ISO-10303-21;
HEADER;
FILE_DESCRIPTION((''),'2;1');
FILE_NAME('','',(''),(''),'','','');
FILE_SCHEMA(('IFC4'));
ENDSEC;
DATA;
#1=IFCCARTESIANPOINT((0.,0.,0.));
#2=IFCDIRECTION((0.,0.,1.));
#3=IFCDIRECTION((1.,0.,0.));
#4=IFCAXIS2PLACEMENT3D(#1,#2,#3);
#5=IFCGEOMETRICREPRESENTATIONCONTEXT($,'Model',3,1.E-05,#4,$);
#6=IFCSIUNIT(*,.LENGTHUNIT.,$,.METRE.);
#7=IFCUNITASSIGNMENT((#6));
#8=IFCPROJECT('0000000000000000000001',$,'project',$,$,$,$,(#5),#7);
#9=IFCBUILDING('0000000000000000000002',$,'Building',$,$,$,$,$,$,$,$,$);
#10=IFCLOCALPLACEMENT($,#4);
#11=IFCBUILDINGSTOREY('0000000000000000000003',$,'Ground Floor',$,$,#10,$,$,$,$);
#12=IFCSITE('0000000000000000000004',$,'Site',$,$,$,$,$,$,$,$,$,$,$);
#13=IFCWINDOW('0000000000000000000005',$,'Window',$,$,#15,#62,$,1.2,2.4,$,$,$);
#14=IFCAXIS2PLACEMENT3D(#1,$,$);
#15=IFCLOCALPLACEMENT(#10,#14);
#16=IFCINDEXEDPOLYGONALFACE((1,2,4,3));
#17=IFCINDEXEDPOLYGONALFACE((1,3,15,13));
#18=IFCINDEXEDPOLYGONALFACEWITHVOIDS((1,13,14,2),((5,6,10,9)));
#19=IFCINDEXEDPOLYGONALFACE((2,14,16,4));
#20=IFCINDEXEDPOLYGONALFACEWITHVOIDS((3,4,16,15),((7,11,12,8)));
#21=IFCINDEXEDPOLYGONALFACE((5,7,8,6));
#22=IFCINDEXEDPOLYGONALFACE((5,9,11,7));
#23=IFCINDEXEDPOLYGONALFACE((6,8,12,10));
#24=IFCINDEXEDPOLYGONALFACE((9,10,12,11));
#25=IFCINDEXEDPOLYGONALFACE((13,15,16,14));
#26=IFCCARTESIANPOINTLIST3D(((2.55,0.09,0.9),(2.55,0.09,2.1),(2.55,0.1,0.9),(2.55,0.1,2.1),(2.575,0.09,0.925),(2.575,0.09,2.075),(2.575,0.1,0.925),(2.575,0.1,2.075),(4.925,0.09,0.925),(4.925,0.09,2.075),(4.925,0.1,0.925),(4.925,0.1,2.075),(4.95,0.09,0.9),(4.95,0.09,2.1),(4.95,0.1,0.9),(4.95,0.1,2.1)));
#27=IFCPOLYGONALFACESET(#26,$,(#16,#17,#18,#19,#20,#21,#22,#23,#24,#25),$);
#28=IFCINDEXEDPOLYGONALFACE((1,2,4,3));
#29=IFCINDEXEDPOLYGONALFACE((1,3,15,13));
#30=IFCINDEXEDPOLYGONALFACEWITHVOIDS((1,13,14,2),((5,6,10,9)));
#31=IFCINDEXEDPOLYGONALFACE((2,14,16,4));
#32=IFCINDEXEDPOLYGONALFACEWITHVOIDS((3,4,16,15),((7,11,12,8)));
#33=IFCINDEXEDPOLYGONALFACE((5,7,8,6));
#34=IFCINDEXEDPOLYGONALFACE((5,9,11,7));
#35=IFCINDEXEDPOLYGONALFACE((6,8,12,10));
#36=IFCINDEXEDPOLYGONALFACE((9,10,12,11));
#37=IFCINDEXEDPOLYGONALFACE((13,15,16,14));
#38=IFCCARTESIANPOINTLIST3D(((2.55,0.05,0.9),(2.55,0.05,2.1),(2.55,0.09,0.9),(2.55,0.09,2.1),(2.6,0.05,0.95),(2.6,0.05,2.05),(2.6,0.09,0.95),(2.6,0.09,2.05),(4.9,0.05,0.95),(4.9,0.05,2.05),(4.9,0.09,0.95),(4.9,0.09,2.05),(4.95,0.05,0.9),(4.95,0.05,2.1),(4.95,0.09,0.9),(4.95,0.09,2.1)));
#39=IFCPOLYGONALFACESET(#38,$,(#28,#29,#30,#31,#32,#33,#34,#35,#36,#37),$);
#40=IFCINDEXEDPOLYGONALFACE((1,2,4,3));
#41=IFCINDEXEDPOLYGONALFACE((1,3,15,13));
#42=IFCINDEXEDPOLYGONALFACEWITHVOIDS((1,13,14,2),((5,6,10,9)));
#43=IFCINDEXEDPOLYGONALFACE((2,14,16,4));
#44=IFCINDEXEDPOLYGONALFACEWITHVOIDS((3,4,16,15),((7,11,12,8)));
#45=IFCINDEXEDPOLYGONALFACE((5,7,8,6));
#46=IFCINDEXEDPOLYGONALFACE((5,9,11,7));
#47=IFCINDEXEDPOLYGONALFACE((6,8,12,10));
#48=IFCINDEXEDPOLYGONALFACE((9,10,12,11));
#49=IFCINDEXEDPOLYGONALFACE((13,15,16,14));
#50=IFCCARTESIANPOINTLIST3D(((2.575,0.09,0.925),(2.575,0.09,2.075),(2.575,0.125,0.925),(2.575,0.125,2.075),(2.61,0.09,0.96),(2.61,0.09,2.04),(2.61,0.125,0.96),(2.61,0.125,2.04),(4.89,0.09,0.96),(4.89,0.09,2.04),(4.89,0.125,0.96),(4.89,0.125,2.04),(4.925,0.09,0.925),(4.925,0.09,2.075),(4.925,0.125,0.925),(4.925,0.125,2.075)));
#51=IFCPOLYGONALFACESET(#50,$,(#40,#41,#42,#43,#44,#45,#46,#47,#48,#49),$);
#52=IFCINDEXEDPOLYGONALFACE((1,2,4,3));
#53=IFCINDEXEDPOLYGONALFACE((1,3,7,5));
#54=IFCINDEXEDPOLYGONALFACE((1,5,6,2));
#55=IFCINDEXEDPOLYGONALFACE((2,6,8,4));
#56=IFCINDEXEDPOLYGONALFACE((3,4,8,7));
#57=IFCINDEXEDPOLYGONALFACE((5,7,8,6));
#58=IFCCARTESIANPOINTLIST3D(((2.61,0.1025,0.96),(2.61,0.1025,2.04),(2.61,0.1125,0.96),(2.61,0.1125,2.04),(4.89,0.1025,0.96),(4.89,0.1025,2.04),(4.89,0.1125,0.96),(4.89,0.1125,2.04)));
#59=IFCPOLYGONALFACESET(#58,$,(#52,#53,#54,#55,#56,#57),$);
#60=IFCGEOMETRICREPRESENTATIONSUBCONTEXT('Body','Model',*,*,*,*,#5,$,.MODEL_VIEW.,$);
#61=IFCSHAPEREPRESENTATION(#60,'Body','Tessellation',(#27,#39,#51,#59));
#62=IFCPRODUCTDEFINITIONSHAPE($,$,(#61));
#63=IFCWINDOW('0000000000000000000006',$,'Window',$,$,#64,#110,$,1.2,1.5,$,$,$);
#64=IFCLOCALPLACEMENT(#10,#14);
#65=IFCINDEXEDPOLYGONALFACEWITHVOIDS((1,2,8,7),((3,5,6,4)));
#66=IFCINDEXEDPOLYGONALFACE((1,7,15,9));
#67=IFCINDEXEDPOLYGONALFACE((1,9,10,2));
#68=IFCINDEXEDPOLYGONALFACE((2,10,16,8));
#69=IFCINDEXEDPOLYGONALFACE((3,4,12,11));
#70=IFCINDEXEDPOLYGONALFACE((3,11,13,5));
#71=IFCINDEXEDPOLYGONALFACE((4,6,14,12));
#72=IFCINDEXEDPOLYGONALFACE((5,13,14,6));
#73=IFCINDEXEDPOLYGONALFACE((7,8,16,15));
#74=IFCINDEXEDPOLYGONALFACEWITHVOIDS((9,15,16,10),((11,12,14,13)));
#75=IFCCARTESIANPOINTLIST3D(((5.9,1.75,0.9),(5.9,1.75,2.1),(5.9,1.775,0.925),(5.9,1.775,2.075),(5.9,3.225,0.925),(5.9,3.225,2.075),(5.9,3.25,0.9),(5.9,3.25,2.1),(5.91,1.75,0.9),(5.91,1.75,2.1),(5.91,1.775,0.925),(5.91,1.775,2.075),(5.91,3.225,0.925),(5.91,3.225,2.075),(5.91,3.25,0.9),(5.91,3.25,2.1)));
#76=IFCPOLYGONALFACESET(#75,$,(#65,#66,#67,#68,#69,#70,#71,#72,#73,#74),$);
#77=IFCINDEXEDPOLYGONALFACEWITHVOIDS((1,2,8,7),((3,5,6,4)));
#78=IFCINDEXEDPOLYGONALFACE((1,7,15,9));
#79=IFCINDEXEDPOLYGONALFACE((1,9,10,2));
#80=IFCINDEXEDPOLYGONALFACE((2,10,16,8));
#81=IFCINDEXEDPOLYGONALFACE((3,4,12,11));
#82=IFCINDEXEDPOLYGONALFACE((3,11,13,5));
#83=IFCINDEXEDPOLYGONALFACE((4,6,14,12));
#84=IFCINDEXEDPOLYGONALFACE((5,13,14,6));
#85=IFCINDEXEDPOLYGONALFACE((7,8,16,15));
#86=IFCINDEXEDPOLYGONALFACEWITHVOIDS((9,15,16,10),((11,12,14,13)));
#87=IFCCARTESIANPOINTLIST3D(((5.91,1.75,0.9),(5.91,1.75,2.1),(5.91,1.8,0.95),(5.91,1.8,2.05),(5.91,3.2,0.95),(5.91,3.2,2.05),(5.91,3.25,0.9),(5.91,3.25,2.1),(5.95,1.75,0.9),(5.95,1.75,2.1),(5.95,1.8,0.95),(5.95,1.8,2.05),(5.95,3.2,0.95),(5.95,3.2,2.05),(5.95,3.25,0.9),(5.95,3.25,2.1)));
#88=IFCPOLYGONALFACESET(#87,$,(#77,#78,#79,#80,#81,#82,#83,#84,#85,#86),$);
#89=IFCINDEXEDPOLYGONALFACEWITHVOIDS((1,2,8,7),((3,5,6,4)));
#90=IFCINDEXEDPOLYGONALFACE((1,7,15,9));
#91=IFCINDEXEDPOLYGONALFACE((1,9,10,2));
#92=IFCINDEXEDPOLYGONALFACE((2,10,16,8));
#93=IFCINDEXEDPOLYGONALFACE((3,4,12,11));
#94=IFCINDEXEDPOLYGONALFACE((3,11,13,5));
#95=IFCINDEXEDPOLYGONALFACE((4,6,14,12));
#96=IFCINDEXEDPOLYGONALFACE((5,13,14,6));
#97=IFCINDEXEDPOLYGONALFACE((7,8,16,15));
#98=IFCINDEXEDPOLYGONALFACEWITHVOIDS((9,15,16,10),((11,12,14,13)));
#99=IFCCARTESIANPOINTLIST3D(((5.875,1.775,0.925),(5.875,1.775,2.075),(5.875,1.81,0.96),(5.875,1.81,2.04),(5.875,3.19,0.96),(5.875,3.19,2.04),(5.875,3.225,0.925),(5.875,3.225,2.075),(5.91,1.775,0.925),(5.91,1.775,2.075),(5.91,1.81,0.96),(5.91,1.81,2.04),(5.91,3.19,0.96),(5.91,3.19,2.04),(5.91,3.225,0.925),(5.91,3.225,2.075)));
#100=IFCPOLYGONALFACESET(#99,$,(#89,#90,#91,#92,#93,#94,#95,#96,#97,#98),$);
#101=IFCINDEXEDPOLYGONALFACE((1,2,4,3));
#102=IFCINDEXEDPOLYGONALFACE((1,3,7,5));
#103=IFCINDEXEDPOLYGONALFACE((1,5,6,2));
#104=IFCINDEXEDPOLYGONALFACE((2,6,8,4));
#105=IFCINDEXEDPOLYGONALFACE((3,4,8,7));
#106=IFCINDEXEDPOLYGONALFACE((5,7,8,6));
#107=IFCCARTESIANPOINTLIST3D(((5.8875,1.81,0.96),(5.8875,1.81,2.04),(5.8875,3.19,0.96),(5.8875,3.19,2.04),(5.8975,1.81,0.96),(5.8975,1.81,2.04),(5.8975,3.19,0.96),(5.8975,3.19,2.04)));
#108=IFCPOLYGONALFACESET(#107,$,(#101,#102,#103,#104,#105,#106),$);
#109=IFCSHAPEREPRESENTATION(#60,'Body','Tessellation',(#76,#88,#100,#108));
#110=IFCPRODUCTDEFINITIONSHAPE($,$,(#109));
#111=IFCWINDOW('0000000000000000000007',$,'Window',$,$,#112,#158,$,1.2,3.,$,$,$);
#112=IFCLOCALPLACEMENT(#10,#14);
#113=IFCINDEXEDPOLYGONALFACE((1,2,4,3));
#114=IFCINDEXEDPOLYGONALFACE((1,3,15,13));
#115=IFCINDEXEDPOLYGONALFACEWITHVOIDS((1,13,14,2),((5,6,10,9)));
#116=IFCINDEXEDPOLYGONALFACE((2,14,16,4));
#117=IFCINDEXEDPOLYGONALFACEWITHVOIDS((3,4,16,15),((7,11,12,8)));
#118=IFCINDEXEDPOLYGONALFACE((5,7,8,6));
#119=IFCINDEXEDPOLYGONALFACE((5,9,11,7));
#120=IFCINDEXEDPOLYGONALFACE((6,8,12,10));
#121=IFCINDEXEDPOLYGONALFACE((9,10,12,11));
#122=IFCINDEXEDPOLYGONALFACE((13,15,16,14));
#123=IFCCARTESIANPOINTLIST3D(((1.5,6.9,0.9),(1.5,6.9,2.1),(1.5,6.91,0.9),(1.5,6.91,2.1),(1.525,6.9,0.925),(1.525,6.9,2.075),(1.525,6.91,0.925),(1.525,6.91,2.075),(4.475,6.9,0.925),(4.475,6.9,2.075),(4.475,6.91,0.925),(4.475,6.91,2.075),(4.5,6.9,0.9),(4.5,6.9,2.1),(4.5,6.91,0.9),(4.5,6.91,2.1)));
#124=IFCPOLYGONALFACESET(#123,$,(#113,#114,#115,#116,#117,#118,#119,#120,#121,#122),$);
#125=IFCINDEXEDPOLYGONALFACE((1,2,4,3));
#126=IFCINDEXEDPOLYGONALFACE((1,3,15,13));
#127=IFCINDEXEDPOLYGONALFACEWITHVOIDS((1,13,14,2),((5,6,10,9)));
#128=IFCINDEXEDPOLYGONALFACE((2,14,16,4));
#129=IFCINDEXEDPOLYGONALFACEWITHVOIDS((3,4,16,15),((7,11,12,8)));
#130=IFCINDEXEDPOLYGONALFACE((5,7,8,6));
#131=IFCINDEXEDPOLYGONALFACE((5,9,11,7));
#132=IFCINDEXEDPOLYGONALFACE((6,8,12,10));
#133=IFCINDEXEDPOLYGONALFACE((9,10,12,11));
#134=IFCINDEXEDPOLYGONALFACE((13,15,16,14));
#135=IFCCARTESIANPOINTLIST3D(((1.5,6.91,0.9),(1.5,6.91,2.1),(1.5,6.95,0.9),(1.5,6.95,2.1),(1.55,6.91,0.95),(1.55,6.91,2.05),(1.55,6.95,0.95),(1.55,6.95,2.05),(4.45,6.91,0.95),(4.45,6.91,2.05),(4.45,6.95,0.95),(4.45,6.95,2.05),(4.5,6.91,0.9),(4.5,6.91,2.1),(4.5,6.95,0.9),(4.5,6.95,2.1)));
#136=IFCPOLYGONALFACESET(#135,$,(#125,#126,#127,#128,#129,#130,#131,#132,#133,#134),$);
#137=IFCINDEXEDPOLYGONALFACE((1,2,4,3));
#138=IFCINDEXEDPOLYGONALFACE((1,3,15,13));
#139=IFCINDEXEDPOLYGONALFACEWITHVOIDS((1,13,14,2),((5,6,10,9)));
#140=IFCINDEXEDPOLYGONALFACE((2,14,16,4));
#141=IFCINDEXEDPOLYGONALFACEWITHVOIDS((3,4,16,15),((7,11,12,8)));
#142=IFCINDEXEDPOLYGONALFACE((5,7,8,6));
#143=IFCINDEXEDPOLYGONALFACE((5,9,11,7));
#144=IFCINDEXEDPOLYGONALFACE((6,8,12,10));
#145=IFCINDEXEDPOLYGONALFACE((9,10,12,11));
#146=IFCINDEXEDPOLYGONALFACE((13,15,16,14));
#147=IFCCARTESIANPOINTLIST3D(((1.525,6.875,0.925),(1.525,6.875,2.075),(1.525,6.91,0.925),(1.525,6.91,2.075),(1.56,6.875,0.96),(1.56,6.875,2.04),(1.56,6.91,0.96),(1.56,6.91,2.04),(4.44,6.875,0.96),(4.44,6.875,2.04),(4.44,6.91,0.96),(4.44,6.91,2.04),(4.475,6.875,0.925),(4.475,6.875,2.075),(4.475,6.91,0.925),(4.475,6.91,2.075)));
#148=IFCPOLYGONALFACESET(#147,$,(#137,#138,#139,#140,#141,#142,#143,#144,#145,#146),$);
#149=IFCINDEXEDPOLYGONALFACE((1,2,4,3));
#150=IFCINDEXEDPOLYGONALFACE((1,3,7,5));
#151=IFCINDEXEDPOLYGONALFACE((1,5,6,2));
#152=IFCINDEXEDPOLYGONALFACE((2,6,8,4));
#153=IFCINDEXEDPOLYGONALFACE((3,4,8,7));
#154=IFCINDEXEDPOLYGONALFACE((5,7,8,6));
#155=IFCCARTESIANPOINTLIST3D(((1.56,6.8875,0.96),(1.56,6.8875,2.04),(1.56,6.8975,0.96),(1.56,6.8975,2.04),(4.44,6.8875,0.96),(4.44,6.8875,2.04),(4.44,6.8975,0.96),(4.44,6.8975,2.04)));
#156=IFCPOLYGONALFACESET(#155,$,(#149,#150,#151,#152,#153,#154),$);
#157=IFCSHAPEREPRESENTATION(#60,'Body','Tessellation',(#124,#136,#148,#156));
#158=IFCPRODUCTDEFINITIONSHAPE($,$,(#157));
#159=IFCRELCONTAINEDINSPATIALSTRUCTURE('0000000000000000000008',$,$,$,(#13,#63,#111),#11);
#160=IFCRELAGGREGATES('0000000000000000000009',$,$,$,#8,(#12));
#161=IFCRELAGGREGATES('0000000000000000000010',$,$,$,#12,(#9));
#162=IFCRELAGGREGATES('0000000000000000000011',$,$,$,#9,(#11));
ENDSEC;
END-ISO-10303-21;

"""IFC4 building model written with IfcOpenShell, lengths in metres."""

from ifc_helpers import new_model, si_unit, frame, origin_with_axes, place, context, subcontext, project, spatial, line, indexed_curve, outline, extrude, element, save


model = new_model("IFC4")

# Units and contexts
model_context = context("Model", 3, precision=1e-05, world=origin_with_axes())
body_context = subcontext(model_context, "Body", "Model", "MODEL_VIEW")
ifc_project = project(units=[si_unit("LENGTHUNIT", "METRE")], contexts=[model_context])

# Site, building, storey
site = spatial("IfcSite", under=ifc_project, Name="Site")
building = spatial("IfcBuilding", under=site, Name="Building")
storey_placement = place(None, origin_with_axes())
storey = spatial("IfcBuildingStorey", under=building, at=storey_placement, Name="Ground Floor")

# Windows
window_1_placement = place(storey_placement, frame((2.55, 0.0, 0.9), z_axis=(0.0, 0.0, 1.0), x_axis=(1.0, 0.0, 0.0)))
element("IfcWindow", 1, at=window_1_placement, inside=storey, Name="Window", OverallHeight=1.2, OverallWidth=2.4, context=body_context, shape_type="SweptSolid", body=[
    extrude(outline(indexed_curve([(0.0, 0.0), (2.4, 0.0), (2.4, 1.2), (0.0, 1.2)], segments=[line(1, 2, 3, 4, 1)]), holes=[indexed_curve([(0.025, 0.025), (2.375, 0.025), (2.375, 1.175), (0.025, 1.175)], segments=[line(1, 2, 3, 4, 1)])]), frame((0.0, 0.09, 0.0), z_axis=(0.0, -1.0, 0.0), x_axis=(1.0, 0.0, 0.0)), (0.0, 0.0, -1.0), 0.01),
    extrude(outline(indexed_curve([(0.0, 0.0), (2.4, 0.0), (2.4, 1.2), (0.0, 1.2)], segments=[line(1, 2, 3, 4, 1)]), holes=[indexed_curve([(0.05, 0.05), (2.35, 0.05), (2.35, 1.15), (0.05, 1.15)], segments=[line(1, 2, 3, 4, 1)])]), frame((0.0, 0.05, 0.0), z_axis=(0.0, -1.0, 0.0), x_axis=(1.0, 0.0, 0.0)), (0.0, 0.0, -1.0), 0.04),
    extrude(outline(indexed_curve([(0.0, 0.0), (2.35, 0.0), (2.35, 1.15), (0.0, 1.15)], segments=[line(1, 2, 3, 4, 1)]), holes=[indexed_curve([(0.035, 0.035), (2.315, 0.035), (2.315, 1.115), (0.035, 1.115)], segments=[line(1, 2, 3, 4, 1)])]), frame((0.025, 0.09, 0.025), z_axis=(0.0, -1.0, 0.0), x_axis=(1.0, 0.0, 0.0)), (0.0, 0.0, -1.0), 0.035),
    extrude(outline(indexed_curve([(0.035, 0.035), (2.315, 0.035), (2.315, 1.115), (0.035, 1.115)], segments=[line(1, 2, 3, 4, 1)])), frame((0.025, 0.1025, 0.025), z_axis=(0.0, -1.0, 0.0), x_axis=(1.0, 0.0, 0.0)), (0.0, 0.0, -1.0), 0.01),
])
window_2_placement = place(storey_placement, frame((6.0, 1.75, 0.9), z_axis=(0.0, 0.0, 1.0), x_axis=(0.0, 1.0, 0.0)))
element("IfcWindow", 2, at=window_2_placement, inside=storey, Name="Window", OverallHeight=1.2, OverallWidth=1.5, context=body_context, shape_type="SweptSolid", body=[
    extrude(outline(indexed_curve([(0.0, 0.0), (1.5, 0.0), (1.5, 1.2), (0.0, 1.2)], segments=[line(1, 2, 3, 4, 1)]), holes=[indexed_curve([(0.025, 0.025), (1.475, 0.025), (1.475, 1.175), (0.025, 1.175)], segments=[line(1, 2, 3, 4, 1)])]), frame((0.0, 0.09, 0.0), z_axis=(0.0, -1.0, 0.0), x_axis=(1.0, 0.0, 0.0)), (0.0, 0.0, -1.0), 0.01),
    extrude(outline(indexed_curve([(0.0, 0.0), (1.5, 0.0), (1.5, 1.2), (0.0, 1.2)], segments=[line(1, 2, 3, 4, 1)]), holes=[indexed_curve([(0.05, 0.05), (1.45, 0.05), (1.45, 1.15), (0.05, 1.15)], segments=[line(1, 2, 3, 4, 1)])]), frame((0.0, 0.05, 0.0), z_axis=(0.0, -1.0, 0.0), x_axis=(1.0, 0.0, 0.0)), (0.0, 0.0, -1.0), 0.04),
    extrude(outline(indexed_curve([(0.0, 0.0), (1.45, 0.0), (1.45, 1.15), (0.0, 1.15)], segments=[line(1, 2, 3, 4, 1)]), holes=[indexed_curve([(0.035, 0.035), (1.415, 0.035), (1.415, 1.115), (0.035, 1.115)], segments=[line(1, 2, 3, 4, 1)])]), frame((0.025, 0.09, 0.025), z_axis=(0.0, -1.0, 0.0), x_axis=(1.0, 0.0, 0.0)), (0.0, 0.0, -1.0), 0.035),
    extrude(outline(indexed_curve([(0.035, 0.035), (1.415, 0.035), (1.415, 1.115), (0.035, 1.115)], segments=[line(1, 2, 3, 4, 1)])), frame((0.025, 0.1025, 0.025), z_axis=(0.0, -1.0, 0.0), x_axis=(1.0, 0.0, 0.0)), (0.0, 0.0, -1.0), 0.01),
])
window_3_placement = place(storey_placement, frame((4.5, 7.0, 0.9), z_axis=(0.0, 0.0, 1.0), x_axis=(-1.0, 0.0, 0.0)))
element("IfcWindow", 3, at=window_3_placement, inside=storey, Name="Window", OverallHeight=1.2, OverallWidth=3.0, context=body_context, shape_type="SweptSolid", body=[
    extrude(outline(indexed_curve([(0.0, 0.0), (3.0, 0.0), (3.0, 1.2), (0.0, 1.2)], segments=[line(1, 2, 3, 4, 1)]), holes=[indexed_curve([(0.025, 0.025), (2.975, 0.025), (2.975, 1.175), (0.025, 1.175)], segments=[line(1, 2, 3, 4, 1)])]), frame((0.0, 0.09, 0.0), z_axis=(0.0, -1.0, 0.0), x_axis=(1.0, 0.0, 0.0)), (0.0, 0.0, -1.0), 0.01),
    extrude(outline(indexed_curve([(0.0, 0.0), (3.0, 0.0), (3.0, 1.2), (0.0, 1.2)], segments=[line(1, 2, 3, 4, 1)]), holes=[indexed_curve([(0.05, 0.05), (2.95, 0.05), (2.95, 1.15), (0.05, 1.15)], segments=[line(1, 2, 3, 4, 1)])]), frame((0.0, 0.05, 0.0), z_axis=(0.0, -1.0, 0.0), x_axis=(1.0, 0.0, 0.0)), (0.0, 0.0, -1.0), 0.04),
    extrude(outline(indexed_curve([(0.0, 0.0), (2.95, 0.0), (2.95, 1.15), (0.0, 1.15)], segments=[line(1, 2, 3, 4, 1)]), holes=[indexed_curve([(0.035, 0.035), (2.915, 0.035), (2.915, 1.115), (0.035, 1.115)], segments=[line(1, 2, 3, 4, 1)])]), frame((0.025, 0.09, 0.025), z_axis=(0.0, -1.0, 0.0), x_axis=(1.0, 0.0, 0.0)), (0.0, 0.0, -1.0), 0.035),
    extrude(outline(indexed_curve([(0.035, 0.035), (2.915, 0.035), (2.915, 1.115), (0.035, 1.115)], segments=[line(1, 2, 3, 4, 1)])), frame((0.025, 0.1025, 0.025), z_axis=(0.0, -1.0, 0.0), x_axis=(1.0, 0.0, 0.0)), (0.0, 0.0, -1.0), 0.01),
])

save(model, "model.ifc")
